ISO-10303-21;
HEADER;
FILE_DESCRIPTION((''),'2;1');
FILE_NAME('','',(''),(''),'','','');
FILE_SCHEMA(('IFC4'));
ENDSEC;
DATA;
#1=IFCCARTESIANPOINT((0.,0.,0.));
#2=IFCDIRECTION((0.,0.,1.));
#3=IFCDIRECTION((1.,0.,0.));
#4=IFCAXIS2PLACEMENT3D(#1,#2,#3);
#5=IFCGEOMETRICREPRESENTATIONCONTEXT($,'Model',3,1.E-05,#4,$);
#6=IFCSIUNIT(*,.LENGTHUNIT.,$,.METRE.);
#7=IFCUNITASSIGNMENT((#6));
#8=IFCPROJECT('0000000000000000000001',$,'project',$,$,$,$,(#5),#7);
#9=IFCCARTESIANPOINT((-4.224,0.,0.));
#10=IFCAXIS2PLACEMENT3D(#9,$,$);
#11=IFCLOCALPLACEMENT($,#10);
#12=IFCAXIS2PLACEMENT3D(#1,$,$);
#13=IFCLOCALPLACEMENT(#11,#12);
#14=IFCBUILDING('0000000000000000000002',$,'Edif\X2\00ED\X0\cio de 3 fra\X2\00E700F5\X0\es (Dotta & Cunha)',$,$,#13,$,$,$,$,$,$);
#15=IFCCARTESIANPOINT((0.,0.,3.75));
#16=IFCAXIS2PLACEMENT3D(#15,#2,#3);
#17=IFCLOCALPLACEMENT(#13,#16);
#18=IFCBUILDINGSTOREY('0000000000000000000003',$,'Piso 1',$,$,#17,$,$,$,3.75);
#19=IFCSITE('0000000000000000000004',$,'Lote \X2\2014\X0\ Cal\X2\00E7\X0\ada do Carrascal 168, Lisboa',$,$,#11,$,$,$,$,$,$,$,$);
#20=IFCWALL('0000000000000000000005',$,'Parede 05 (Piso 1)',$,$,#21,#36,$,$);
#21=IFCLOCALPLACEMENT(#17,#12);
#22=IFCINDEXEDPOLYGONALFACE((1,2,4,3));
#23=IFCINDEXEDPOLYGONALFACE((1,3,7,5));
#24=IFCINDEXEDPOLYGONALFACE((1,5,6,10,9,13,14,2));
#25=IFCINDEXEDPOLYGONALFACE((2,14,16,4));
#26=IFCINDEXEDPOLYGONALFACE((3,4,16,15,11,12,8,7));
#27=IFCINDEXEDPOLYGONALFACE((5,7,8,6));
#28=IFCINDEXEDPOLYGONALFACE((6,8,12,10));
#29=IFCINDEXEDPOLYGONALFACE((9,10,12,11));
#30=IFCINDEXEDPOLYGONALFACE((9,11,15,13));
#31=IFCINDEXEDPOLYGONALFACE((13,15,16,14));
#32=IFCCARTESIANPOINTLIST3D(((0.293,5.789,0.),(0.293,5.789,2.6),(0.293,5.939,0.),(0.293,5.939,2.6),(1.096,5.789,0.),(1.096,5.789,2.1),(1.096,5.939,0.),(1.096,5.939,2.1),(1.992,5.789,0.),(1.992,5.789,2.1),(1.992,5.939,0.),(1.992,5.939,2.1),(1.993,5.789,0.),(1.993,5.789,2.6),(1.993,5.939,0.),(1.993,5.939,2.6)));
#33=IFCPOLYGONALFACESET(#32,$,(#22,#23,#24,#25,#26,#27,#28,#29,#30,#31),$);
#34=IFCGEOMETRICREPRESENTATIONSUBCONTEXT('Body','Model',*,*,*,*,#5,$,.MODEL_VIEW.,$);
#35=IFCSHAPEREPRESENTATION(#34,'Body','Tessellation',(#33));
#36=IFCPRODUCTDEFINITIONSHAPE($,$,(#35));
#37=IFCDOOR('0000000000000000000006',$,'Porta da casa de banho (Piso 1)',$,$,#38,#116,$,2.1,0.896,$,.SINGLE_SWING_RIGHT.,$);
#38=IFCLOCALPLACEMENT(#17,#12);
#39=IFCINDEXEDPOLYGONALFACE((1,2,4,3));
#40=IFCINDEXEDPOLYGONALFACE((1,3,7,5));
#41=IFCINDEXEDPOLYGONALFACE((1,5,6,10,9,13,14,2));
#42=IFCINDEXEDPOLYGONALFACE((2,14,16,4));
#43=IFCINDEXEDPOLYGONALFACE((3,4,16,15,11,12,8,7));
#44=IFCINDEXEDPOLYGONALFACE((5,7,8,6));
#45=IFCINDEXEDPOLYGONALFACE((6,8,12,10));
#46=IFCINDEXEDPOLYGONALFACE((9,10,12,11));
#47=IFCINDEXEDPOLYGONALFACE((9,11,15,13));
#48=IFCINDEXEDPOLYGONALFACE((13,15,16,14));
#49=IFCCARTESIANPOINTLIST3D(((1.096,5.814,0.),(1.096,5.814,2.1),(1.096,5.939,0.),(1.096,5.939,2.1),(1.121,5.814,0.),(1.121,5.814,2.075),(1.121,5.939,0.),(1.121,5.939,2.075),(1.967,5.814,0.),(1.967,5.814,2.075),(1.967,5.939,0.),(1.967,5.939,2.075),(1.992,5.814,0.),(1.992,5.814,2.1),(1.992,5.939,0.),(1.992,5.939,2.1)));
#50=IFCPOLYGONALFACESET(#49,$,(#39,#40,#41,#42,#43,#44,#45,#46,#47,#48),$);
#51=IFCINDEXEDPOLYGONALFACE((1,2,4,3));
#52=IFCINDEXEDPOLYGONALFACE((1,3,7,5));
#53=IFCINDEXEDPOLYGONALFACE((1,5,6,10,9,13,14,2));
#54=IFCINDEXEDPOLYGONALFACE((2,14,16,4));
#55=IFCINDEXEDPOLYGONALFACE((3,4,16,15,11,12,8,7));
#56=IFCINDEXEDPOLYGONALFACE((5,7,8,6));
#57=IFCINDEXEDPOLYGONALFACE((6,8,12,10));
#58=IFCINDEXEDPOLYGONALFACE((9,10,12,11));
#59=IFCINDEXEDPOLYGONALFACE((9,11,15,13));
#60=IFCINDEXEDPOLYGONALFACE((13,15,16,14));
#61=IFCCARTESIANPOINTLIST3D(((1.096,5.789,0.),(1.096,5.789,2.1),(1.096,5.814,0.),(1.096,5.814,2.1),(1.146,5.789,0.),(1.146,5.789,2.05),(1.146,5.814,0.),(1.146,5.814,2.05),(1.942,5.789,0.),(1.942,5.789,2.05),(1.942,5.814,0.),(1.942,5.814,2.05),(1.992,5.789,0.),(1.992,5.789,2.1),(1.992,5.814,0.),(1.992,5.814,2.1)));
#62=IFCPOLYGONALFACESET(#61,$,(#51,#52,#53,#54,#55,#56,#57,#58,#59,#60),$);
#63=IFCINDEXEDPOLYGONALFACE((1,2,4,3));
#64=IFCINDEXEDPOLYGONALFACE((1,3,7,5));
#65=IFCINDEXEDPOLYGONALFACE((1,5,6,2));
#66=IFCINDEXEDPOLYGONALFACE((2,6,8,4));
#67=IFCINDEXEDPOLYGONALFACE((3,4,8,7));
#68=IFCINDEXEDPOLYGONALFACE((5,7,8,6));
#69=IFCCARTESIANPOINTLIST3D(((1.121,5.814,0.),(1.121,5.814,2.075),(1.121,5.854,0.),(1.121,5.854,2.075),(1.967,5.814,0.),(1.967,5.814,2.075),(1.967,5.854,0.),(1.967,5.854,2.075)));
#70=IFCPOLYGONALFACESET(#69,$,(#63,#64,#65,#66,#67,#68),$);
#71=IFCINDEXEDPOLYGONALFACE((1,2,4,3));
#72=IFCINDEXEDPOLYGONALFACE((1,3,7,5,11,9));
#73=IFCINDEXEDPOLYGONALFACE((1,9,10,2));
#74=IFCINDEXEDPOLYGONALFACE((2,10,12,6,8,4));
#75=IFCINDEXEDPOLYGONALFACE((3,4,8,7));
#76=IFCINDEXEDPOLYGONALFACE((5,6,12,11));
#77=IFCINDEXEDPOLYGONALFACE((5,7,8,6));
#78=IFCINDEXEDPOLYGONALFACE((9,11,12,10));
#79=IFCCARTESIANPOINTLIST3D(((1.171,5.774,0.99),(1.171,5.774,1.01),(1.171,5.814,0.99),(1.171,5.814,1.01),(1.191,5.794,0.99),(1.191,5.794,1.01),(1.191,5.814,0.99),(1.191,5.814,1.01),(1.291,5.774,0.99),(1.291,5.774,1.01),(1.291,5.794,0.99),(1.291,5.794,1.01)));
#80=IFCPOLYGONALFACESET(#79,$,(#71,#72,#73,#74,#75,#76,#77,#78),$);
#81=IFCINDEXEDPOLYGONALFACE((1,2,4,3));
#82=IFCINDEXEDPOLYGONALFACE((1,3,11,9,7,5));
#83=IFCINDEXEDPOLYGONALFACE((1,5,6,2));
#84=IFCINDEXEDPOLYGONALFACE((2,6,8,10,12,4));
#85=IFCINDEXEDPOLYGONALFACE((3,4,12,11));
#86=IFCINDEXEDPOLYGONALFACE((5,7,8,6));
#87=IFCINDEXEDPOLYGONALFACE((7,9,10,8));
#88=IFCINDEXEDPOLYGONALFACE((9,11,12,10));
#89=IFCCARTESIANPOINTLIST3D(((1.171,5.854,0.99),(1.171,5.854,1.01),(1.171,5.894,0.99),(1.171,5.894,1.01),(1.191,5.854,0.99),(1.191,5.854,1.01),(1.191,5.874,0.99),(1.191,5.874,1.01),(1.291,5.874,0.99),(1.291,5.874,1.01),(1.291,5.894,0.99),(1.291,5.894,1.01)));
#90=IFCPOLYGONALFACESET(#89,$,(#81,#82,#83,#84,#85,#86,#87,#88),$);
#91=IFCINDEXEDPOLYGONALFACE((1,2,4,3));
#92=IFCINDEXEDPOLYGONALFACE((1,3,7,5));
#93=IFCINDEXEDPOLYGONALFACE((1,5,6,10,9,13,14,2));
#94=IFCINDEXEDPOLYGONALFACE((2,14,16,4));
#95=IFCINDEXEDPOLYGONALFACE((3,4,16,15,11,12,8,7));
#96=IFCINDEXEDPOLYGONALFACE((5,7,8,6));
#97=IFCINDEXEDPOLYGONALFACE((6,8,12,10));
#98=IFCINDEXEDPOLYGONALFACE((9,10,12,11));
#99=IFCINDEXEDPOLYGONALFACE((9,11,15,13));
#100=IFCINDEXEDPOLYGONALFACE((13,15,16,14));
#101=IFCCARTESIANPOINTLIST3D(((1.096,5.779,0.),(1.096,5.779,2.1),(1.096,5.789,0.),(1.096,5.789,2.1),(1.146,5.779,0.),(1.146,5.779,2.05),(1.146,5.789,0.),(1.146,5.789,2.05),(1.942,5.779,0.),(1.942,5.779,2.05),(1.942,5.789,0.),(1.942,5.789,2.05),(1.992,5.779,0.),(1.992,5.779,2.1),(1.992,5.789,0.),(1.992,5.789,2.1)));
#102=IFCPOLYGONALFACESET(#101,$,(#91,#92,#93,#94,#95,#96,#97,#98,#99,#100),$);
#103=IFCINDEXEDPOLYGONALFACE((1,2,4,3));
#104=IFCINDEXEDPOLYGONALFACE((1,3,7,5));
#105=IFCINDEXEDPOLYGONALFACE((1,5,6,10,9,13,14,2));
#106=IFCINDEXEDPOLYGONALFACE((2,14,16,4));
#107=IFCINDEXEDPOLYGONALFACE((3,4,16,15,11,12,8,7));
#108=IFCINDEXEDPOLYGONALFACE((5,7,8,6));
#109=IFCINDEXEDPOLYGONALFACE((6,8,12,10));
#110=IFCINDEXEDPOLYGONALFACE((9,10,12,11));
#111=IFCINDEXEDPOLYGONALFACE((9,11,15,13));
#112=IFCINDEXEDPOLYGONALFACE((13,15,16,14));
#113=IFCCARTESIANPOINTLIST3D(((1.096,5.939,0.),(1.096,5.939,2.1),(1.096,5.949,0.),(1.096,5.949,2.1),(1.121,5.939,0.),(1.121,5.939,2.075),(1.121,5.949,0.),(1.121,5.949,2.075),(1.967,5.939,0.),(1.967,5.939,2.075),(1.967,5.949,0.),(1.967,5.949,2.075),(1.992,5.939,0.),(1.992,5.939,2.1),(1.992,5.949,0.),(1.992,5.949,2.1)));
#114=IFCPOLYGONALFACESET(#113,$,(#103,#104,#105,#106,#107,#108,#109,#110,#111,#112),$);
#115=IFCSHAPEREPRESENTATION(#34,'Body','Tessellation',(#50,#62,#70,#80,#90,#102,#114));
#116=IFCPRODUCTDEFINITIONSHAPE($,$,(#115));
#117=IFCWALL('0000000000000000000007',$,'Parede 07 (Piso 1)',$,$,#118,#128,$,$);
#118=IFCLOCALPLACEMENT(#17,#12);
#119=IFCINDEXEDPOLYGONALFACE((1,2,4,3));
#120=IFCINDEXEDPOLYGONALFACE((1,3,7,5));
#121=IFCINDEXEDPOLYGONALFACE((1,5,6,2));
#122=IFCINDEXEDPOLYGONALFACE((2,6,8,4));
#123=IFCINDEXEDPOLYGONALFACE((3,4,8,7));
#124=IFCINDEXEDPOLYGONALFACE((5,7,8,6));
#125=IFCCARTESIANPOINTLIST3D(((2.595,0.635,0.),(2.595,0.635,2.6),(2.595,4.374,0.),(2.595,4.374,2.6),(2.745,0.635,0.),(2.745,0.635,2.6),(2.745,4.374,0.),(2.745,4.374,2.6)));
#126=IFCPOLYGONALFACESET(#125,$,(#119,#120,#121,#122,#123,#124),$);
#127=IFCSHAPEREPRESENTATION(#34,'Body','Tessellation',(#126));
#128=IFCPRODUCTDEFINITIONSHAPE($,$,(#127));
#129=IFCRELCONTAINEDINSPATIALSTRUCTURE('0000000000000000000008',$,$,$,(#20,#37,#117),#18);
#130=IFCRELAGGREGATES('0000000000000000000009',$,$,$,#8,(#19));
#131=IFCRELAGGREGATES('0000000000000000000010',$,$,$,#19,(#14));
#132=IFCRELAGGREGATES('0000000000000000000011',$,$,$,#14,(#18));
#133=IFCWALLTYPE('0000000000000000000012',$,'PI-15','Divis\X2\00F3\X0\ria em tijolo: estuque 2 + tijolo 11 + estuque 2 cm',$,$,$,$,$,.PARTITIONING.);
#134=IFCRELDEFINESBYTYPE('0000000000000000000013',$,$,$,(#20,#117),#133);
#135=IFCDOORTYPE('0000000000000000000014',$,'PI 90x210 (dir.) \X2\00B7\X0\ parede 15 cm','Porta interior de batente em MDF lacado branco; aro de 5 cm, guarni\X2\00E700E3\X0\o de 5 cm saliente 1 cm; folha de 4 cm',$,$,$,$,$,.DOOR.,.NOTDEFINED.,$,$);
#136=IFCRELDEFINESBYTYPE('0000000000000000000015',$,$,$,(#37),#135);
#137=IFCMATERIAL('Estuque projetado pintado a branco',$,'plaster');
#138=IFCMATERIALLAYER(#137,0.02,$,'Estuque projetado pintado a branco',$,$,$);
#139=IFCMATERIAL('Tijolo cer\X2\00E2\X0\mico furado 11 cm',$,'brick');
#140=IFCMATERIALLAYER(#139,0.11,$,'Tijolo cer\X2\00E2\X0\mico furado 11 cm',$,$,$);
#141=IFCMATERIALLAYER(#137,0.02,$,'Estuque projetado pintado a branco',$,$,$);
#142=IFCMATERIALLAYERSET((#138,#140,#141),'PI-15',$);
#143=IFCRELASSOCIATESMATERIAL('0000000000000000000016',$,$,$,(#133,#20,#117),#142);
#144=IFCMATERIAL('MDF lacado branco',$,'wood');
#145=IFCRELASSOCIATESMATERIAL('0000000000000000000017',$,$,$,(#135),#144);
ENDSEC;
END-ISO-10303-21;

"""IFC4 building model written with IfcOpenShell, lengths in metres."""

from ifc_helpers import new_model, si_unit, frame, origin, origin_with_axes, place, context, subcontext, project, spatial, line, indexed_curve, outline, extrude, source, transform, mapped, material, layer, layer_set, layer_usage, type_object, type_shapes, element, fill, save


model = new_model("IFC4")

# Units and contexts
model_context = context("Model", 3, precision=1e-05, world=origin_with_axes())
body_context = subcontext(model_context, "Body", "Model", "MODEL_VIEW")
ifc_project = project(units=[si_unit("LENGTHUNIT", "METRE")], contexts=[model_context])

# Site, building, storey
site_placement = place(None, frame((-4.224, 0.0, 0.0)))
site = spatial("IfcSite", under=ifc_project, at=site_placement, Name="Lote — Calçada do Carrascal 168, Lisboa")
building_placement = place(site_placement, origin())
building = spatial("IfcBuilding", under=site, at=building_placement, Name="Edifício de 3 frações (Dotta & Cunha)")
storey_placement = place(building_placement, frame((0.0, 0.0, 3.75), z_axis=(0.0, 0.0, 1.0), x_axis=(1.0, 0.0, 0.0)))
storey = spatial("IfcBuildingStorey", under=building, at=storey_placement, Name="Piso 1", Elevation=3.75)

# Shared definitions
ifc_material_1 = material(Name="Estuque projetado pintado a branco", Category="plaster")
ifc_layer_1 = layer(ifc_material_1, 0.02, Name="Estuque projetado pintado a branco")
ifc_material_2 = material(Name="Tijolo cerâmico furado 11 cm", Category="brick")
ifc_layer_2 = layer(ifc_material_2, 0.11, Name="Tijolo cerâmico furado 11 cm")
ifc_layer_3 = layer(ifc_material_1, 0.02, Name="Estuque projetado pintado a branco")
ifc_layer_set_1 = layer_set([ifc_layer_1, ifc_layer_2, ifc_layer_3], Name="PI-15")
wall_type_1 = type_object("IfcWallType", Name="PI-15", Description="Divisória em tijolo: estuque 2 + tijolo 11 + estuque 2 cm", PredefinedType="PARTITIONING", material=ifc_layer_set_1)

# Wall, opening, door
ifc_layer_usage_1 = layer_usage(ifc_layer_set_1, "AXIS2", "POSITIVE", 0.0)
wall_1_placement = place(storey_placement, origin_with_axes())
wall_1 = element("IfcWall", 1, at=wall_1_placement, inside=storey, type_object=wall_type_1, material=ifc_layer_usage_1, Name="Parede 05 (Piso 1)", context=body_context, shape_type="SweptSolid", body=[
    extrude(outline(indexed_curve([(1.993, 5.789), (1.993, 5.939), (0.293, 5.939), (0.293, 5.789)], segments=[line(1, 2, 3, 4, 1)])), origin_with_axes(), (0.0, 0.0, 1.0), 2.6),
])
opening_1_placement = place(wall_1_placement, origin_with_axes())
opening_1 = element("IfcOpeningElement", 2, at=opening_1_placement, cuts=wall_1, context=body_context, shape_type="SweptSolid", body=[
    extrude(outline(indexed_curve([(1.992, 5.787), (1.992, 5.941), (1.096, 5.941), (1.096, 5.787)], segments=[line(1, 2, 3, 4, 1)])), origin_with_axes(), (0.0, 0.0, 1.0), 2.1),
])
ifc_material_3 = material(Name="MDF lacado branco", Category="wood")
door_type_1 = type_object("IfcDoorType", Name="PI 90x210 (dir.) · parede 15 cm", Description="Porta interior de batente em MDF lacado branco; aro de 5 cm, guarnição de 5 cm saliente 1 cm; folha de 4 cm", OperationType="NOTDEFINED", PredefinedType="DOOR", material=ifc_material_3)
shared_shape_1 = source(origin_with_axes(), body_context, "Body", "SweptSolid", [
    extrude(outline(indexed_curve([(0.0, 0.0), (0.0, 2.1), (0.896, 2.1), (0.896, 0.0), (0.871, 0.0), (0.871, 2.075), (0.025, 2.075), (0.025, 0.0)], segments=[line(1, 2, 3, 4, 5, 6, 7, 8, 1)])), frame((0.0, 0.025, 0.0), z_axis=(0.0, -1.0, 0.0), x_axis=(1.0, 0.0, 0.0)), (0.0, 0.0, -1.0), 0.125),
    extrude(outline(indexed_curve([(0.0, 0.0), (0.0, 2.1), (0.896, 2.1), (0.896, 0.0), (0.846, 0.0), (0.846, 2.05), (0.05, 2.05), (0.05, 0.0)], segments=[line(1, 2, 3, 4, 5, 6, 7, 8, 1)])), frame((0.0, 0.0, 0.0), z_axis=(0.0, -1.0, 0.0), x_axis=(1.0, 0.0, 0.0)), (0.0, 0.0, -1.0), 0.025),
    extrude(outline(indexed_curve([(0.0, 0.0), (0.846, 0.0), (0.846, 0.04), (0.0, 0.04)], segments=[line(1, 2, 3, 4, 1)])), frame((0.025, 0.025, 0.0), z_axis=(0.0, 0.0, 1.0), x_axis=(1.0, 0.0, 0.0)), (0.0, 0.0, 1.0), 2.075),
    extrude(outline(indexed_curve([(0.0, 0.0), (0.0, -0.04), (0.12, -0.04), (0.12, -0.02), (0.02, -0.02), (0.02, 0.0)], segments=[line(1, 2, 3, 4, 5, 6, 1)])), frame((0.075, 0.025, 0.99), z_axis=(0.0, 0.0, 1.0), x_axis=(1.0, 0.0, 0.0)), (0.0, 0.0, 1.0), 0.02),
    extrude(outline(indexed_curve([(0.0, 0.0), (0.0, 0.04), (0.12, 0.04), (0.12, 0.02), (0.02, 0.02), (0.02, 0.0)], segments=[line(1, 2, 3, 4, 5, 6, 1)])), frame((0.075, 0.065, 0.99), z_axis=(0.0, 0.0, 1.0), x_axis=(1.0, 0.0, 0.0)), (0.0, 0.0, 1.0), 0.02),
    extrude(outline(indexed_curve([(0.0, 0.0), (0.0, 2.1), (0.896, 2.1), (0.896, 0.0), (0.846, 0.0), (0.846, 2.05), (0.05, 2.05), (0.05, 0.0)], segments=[line(1, 2, 3, 4, 5, 6, 7, 8, 1)])), frame((0.0, -0.01, 0.0), z_axis=(0.0, -1.0, 0.0), x_axis=(1.0, 0.0, 0.0)), (0.0, 0.0, -1.0), 0.01),
    extrude(outline(indexed_curve([(0.0, 0.0), (0.0, 2.1), (0.896, 2.1), (0.896, 0.0), (0.871, 0.0), (0.871, 2.075), (0.025, 2.075), (0.025, 0.0)], segments=[line(1, 2, 3, 4, 5, 6, 7, 8, 1)])), frame((0.0, 0.15, 0.0), z_axis=(0.0, -1.0, 0.0), x_axis=(1.0, 0.0, 0.0)), (0.0, 0.0, -1.0), 0.01),
])
type_shapes(door_type_1, [shared_shape_1])
door_1_placement = place(storey_placement, frame((1.096, 5.789, 0.0), z_axis=(0.0, 0.0, 1.0), x_axis=(1.0, 0.0, 0.0)))
door_1 = element("IfcDoor", 3, at=door_1_placement, inside=storey, type_object=door_type_1, Name="Porta da casa de banho (Piso 1)", OperationType="SINGLE_SWING_RIGHT", OverallHeight=2.1, OverallWidth=0.896, context=body_context, shape_type="MappedRepresentation", body=[
    mapped(shared_shape_1, transform((0.0, 0.0, 0.0), x_axis=(1.0, 0.0, 0.0), y_axis=(0.0, 1.0, 0.0), z_axis=(0.0, 0.0, 1.0), scale=1.0)),
])
fill(opening_1, door_1)

# Wall
ifc_layer_usage_2 = layer_usage(ifc_layer_set_1, "AXIS2", "POSITIVE", 0.0)
wall_2_placement = place(storey_placement, origin_with_axes())
element("IfcWall", 4, at=wall_2_placement, inside=storey, type_object=wall_type_1, material=ifc_layer_usage_2, Name="Parede 07 (Piso 1)", context=body_context, shape_type="SweptSolid", body=[
    extrude(outline(indexed_curve([(2.745, 0.635), (2.745, 4.374), (2.595, 4.374), (2.595, 0.635)], segments=[line(1, 2, 3, 4, 1)])), origin_with_axes(), (0.0, 0.0, 1.0), 2.6),
])

save(model, "model.ifc")
